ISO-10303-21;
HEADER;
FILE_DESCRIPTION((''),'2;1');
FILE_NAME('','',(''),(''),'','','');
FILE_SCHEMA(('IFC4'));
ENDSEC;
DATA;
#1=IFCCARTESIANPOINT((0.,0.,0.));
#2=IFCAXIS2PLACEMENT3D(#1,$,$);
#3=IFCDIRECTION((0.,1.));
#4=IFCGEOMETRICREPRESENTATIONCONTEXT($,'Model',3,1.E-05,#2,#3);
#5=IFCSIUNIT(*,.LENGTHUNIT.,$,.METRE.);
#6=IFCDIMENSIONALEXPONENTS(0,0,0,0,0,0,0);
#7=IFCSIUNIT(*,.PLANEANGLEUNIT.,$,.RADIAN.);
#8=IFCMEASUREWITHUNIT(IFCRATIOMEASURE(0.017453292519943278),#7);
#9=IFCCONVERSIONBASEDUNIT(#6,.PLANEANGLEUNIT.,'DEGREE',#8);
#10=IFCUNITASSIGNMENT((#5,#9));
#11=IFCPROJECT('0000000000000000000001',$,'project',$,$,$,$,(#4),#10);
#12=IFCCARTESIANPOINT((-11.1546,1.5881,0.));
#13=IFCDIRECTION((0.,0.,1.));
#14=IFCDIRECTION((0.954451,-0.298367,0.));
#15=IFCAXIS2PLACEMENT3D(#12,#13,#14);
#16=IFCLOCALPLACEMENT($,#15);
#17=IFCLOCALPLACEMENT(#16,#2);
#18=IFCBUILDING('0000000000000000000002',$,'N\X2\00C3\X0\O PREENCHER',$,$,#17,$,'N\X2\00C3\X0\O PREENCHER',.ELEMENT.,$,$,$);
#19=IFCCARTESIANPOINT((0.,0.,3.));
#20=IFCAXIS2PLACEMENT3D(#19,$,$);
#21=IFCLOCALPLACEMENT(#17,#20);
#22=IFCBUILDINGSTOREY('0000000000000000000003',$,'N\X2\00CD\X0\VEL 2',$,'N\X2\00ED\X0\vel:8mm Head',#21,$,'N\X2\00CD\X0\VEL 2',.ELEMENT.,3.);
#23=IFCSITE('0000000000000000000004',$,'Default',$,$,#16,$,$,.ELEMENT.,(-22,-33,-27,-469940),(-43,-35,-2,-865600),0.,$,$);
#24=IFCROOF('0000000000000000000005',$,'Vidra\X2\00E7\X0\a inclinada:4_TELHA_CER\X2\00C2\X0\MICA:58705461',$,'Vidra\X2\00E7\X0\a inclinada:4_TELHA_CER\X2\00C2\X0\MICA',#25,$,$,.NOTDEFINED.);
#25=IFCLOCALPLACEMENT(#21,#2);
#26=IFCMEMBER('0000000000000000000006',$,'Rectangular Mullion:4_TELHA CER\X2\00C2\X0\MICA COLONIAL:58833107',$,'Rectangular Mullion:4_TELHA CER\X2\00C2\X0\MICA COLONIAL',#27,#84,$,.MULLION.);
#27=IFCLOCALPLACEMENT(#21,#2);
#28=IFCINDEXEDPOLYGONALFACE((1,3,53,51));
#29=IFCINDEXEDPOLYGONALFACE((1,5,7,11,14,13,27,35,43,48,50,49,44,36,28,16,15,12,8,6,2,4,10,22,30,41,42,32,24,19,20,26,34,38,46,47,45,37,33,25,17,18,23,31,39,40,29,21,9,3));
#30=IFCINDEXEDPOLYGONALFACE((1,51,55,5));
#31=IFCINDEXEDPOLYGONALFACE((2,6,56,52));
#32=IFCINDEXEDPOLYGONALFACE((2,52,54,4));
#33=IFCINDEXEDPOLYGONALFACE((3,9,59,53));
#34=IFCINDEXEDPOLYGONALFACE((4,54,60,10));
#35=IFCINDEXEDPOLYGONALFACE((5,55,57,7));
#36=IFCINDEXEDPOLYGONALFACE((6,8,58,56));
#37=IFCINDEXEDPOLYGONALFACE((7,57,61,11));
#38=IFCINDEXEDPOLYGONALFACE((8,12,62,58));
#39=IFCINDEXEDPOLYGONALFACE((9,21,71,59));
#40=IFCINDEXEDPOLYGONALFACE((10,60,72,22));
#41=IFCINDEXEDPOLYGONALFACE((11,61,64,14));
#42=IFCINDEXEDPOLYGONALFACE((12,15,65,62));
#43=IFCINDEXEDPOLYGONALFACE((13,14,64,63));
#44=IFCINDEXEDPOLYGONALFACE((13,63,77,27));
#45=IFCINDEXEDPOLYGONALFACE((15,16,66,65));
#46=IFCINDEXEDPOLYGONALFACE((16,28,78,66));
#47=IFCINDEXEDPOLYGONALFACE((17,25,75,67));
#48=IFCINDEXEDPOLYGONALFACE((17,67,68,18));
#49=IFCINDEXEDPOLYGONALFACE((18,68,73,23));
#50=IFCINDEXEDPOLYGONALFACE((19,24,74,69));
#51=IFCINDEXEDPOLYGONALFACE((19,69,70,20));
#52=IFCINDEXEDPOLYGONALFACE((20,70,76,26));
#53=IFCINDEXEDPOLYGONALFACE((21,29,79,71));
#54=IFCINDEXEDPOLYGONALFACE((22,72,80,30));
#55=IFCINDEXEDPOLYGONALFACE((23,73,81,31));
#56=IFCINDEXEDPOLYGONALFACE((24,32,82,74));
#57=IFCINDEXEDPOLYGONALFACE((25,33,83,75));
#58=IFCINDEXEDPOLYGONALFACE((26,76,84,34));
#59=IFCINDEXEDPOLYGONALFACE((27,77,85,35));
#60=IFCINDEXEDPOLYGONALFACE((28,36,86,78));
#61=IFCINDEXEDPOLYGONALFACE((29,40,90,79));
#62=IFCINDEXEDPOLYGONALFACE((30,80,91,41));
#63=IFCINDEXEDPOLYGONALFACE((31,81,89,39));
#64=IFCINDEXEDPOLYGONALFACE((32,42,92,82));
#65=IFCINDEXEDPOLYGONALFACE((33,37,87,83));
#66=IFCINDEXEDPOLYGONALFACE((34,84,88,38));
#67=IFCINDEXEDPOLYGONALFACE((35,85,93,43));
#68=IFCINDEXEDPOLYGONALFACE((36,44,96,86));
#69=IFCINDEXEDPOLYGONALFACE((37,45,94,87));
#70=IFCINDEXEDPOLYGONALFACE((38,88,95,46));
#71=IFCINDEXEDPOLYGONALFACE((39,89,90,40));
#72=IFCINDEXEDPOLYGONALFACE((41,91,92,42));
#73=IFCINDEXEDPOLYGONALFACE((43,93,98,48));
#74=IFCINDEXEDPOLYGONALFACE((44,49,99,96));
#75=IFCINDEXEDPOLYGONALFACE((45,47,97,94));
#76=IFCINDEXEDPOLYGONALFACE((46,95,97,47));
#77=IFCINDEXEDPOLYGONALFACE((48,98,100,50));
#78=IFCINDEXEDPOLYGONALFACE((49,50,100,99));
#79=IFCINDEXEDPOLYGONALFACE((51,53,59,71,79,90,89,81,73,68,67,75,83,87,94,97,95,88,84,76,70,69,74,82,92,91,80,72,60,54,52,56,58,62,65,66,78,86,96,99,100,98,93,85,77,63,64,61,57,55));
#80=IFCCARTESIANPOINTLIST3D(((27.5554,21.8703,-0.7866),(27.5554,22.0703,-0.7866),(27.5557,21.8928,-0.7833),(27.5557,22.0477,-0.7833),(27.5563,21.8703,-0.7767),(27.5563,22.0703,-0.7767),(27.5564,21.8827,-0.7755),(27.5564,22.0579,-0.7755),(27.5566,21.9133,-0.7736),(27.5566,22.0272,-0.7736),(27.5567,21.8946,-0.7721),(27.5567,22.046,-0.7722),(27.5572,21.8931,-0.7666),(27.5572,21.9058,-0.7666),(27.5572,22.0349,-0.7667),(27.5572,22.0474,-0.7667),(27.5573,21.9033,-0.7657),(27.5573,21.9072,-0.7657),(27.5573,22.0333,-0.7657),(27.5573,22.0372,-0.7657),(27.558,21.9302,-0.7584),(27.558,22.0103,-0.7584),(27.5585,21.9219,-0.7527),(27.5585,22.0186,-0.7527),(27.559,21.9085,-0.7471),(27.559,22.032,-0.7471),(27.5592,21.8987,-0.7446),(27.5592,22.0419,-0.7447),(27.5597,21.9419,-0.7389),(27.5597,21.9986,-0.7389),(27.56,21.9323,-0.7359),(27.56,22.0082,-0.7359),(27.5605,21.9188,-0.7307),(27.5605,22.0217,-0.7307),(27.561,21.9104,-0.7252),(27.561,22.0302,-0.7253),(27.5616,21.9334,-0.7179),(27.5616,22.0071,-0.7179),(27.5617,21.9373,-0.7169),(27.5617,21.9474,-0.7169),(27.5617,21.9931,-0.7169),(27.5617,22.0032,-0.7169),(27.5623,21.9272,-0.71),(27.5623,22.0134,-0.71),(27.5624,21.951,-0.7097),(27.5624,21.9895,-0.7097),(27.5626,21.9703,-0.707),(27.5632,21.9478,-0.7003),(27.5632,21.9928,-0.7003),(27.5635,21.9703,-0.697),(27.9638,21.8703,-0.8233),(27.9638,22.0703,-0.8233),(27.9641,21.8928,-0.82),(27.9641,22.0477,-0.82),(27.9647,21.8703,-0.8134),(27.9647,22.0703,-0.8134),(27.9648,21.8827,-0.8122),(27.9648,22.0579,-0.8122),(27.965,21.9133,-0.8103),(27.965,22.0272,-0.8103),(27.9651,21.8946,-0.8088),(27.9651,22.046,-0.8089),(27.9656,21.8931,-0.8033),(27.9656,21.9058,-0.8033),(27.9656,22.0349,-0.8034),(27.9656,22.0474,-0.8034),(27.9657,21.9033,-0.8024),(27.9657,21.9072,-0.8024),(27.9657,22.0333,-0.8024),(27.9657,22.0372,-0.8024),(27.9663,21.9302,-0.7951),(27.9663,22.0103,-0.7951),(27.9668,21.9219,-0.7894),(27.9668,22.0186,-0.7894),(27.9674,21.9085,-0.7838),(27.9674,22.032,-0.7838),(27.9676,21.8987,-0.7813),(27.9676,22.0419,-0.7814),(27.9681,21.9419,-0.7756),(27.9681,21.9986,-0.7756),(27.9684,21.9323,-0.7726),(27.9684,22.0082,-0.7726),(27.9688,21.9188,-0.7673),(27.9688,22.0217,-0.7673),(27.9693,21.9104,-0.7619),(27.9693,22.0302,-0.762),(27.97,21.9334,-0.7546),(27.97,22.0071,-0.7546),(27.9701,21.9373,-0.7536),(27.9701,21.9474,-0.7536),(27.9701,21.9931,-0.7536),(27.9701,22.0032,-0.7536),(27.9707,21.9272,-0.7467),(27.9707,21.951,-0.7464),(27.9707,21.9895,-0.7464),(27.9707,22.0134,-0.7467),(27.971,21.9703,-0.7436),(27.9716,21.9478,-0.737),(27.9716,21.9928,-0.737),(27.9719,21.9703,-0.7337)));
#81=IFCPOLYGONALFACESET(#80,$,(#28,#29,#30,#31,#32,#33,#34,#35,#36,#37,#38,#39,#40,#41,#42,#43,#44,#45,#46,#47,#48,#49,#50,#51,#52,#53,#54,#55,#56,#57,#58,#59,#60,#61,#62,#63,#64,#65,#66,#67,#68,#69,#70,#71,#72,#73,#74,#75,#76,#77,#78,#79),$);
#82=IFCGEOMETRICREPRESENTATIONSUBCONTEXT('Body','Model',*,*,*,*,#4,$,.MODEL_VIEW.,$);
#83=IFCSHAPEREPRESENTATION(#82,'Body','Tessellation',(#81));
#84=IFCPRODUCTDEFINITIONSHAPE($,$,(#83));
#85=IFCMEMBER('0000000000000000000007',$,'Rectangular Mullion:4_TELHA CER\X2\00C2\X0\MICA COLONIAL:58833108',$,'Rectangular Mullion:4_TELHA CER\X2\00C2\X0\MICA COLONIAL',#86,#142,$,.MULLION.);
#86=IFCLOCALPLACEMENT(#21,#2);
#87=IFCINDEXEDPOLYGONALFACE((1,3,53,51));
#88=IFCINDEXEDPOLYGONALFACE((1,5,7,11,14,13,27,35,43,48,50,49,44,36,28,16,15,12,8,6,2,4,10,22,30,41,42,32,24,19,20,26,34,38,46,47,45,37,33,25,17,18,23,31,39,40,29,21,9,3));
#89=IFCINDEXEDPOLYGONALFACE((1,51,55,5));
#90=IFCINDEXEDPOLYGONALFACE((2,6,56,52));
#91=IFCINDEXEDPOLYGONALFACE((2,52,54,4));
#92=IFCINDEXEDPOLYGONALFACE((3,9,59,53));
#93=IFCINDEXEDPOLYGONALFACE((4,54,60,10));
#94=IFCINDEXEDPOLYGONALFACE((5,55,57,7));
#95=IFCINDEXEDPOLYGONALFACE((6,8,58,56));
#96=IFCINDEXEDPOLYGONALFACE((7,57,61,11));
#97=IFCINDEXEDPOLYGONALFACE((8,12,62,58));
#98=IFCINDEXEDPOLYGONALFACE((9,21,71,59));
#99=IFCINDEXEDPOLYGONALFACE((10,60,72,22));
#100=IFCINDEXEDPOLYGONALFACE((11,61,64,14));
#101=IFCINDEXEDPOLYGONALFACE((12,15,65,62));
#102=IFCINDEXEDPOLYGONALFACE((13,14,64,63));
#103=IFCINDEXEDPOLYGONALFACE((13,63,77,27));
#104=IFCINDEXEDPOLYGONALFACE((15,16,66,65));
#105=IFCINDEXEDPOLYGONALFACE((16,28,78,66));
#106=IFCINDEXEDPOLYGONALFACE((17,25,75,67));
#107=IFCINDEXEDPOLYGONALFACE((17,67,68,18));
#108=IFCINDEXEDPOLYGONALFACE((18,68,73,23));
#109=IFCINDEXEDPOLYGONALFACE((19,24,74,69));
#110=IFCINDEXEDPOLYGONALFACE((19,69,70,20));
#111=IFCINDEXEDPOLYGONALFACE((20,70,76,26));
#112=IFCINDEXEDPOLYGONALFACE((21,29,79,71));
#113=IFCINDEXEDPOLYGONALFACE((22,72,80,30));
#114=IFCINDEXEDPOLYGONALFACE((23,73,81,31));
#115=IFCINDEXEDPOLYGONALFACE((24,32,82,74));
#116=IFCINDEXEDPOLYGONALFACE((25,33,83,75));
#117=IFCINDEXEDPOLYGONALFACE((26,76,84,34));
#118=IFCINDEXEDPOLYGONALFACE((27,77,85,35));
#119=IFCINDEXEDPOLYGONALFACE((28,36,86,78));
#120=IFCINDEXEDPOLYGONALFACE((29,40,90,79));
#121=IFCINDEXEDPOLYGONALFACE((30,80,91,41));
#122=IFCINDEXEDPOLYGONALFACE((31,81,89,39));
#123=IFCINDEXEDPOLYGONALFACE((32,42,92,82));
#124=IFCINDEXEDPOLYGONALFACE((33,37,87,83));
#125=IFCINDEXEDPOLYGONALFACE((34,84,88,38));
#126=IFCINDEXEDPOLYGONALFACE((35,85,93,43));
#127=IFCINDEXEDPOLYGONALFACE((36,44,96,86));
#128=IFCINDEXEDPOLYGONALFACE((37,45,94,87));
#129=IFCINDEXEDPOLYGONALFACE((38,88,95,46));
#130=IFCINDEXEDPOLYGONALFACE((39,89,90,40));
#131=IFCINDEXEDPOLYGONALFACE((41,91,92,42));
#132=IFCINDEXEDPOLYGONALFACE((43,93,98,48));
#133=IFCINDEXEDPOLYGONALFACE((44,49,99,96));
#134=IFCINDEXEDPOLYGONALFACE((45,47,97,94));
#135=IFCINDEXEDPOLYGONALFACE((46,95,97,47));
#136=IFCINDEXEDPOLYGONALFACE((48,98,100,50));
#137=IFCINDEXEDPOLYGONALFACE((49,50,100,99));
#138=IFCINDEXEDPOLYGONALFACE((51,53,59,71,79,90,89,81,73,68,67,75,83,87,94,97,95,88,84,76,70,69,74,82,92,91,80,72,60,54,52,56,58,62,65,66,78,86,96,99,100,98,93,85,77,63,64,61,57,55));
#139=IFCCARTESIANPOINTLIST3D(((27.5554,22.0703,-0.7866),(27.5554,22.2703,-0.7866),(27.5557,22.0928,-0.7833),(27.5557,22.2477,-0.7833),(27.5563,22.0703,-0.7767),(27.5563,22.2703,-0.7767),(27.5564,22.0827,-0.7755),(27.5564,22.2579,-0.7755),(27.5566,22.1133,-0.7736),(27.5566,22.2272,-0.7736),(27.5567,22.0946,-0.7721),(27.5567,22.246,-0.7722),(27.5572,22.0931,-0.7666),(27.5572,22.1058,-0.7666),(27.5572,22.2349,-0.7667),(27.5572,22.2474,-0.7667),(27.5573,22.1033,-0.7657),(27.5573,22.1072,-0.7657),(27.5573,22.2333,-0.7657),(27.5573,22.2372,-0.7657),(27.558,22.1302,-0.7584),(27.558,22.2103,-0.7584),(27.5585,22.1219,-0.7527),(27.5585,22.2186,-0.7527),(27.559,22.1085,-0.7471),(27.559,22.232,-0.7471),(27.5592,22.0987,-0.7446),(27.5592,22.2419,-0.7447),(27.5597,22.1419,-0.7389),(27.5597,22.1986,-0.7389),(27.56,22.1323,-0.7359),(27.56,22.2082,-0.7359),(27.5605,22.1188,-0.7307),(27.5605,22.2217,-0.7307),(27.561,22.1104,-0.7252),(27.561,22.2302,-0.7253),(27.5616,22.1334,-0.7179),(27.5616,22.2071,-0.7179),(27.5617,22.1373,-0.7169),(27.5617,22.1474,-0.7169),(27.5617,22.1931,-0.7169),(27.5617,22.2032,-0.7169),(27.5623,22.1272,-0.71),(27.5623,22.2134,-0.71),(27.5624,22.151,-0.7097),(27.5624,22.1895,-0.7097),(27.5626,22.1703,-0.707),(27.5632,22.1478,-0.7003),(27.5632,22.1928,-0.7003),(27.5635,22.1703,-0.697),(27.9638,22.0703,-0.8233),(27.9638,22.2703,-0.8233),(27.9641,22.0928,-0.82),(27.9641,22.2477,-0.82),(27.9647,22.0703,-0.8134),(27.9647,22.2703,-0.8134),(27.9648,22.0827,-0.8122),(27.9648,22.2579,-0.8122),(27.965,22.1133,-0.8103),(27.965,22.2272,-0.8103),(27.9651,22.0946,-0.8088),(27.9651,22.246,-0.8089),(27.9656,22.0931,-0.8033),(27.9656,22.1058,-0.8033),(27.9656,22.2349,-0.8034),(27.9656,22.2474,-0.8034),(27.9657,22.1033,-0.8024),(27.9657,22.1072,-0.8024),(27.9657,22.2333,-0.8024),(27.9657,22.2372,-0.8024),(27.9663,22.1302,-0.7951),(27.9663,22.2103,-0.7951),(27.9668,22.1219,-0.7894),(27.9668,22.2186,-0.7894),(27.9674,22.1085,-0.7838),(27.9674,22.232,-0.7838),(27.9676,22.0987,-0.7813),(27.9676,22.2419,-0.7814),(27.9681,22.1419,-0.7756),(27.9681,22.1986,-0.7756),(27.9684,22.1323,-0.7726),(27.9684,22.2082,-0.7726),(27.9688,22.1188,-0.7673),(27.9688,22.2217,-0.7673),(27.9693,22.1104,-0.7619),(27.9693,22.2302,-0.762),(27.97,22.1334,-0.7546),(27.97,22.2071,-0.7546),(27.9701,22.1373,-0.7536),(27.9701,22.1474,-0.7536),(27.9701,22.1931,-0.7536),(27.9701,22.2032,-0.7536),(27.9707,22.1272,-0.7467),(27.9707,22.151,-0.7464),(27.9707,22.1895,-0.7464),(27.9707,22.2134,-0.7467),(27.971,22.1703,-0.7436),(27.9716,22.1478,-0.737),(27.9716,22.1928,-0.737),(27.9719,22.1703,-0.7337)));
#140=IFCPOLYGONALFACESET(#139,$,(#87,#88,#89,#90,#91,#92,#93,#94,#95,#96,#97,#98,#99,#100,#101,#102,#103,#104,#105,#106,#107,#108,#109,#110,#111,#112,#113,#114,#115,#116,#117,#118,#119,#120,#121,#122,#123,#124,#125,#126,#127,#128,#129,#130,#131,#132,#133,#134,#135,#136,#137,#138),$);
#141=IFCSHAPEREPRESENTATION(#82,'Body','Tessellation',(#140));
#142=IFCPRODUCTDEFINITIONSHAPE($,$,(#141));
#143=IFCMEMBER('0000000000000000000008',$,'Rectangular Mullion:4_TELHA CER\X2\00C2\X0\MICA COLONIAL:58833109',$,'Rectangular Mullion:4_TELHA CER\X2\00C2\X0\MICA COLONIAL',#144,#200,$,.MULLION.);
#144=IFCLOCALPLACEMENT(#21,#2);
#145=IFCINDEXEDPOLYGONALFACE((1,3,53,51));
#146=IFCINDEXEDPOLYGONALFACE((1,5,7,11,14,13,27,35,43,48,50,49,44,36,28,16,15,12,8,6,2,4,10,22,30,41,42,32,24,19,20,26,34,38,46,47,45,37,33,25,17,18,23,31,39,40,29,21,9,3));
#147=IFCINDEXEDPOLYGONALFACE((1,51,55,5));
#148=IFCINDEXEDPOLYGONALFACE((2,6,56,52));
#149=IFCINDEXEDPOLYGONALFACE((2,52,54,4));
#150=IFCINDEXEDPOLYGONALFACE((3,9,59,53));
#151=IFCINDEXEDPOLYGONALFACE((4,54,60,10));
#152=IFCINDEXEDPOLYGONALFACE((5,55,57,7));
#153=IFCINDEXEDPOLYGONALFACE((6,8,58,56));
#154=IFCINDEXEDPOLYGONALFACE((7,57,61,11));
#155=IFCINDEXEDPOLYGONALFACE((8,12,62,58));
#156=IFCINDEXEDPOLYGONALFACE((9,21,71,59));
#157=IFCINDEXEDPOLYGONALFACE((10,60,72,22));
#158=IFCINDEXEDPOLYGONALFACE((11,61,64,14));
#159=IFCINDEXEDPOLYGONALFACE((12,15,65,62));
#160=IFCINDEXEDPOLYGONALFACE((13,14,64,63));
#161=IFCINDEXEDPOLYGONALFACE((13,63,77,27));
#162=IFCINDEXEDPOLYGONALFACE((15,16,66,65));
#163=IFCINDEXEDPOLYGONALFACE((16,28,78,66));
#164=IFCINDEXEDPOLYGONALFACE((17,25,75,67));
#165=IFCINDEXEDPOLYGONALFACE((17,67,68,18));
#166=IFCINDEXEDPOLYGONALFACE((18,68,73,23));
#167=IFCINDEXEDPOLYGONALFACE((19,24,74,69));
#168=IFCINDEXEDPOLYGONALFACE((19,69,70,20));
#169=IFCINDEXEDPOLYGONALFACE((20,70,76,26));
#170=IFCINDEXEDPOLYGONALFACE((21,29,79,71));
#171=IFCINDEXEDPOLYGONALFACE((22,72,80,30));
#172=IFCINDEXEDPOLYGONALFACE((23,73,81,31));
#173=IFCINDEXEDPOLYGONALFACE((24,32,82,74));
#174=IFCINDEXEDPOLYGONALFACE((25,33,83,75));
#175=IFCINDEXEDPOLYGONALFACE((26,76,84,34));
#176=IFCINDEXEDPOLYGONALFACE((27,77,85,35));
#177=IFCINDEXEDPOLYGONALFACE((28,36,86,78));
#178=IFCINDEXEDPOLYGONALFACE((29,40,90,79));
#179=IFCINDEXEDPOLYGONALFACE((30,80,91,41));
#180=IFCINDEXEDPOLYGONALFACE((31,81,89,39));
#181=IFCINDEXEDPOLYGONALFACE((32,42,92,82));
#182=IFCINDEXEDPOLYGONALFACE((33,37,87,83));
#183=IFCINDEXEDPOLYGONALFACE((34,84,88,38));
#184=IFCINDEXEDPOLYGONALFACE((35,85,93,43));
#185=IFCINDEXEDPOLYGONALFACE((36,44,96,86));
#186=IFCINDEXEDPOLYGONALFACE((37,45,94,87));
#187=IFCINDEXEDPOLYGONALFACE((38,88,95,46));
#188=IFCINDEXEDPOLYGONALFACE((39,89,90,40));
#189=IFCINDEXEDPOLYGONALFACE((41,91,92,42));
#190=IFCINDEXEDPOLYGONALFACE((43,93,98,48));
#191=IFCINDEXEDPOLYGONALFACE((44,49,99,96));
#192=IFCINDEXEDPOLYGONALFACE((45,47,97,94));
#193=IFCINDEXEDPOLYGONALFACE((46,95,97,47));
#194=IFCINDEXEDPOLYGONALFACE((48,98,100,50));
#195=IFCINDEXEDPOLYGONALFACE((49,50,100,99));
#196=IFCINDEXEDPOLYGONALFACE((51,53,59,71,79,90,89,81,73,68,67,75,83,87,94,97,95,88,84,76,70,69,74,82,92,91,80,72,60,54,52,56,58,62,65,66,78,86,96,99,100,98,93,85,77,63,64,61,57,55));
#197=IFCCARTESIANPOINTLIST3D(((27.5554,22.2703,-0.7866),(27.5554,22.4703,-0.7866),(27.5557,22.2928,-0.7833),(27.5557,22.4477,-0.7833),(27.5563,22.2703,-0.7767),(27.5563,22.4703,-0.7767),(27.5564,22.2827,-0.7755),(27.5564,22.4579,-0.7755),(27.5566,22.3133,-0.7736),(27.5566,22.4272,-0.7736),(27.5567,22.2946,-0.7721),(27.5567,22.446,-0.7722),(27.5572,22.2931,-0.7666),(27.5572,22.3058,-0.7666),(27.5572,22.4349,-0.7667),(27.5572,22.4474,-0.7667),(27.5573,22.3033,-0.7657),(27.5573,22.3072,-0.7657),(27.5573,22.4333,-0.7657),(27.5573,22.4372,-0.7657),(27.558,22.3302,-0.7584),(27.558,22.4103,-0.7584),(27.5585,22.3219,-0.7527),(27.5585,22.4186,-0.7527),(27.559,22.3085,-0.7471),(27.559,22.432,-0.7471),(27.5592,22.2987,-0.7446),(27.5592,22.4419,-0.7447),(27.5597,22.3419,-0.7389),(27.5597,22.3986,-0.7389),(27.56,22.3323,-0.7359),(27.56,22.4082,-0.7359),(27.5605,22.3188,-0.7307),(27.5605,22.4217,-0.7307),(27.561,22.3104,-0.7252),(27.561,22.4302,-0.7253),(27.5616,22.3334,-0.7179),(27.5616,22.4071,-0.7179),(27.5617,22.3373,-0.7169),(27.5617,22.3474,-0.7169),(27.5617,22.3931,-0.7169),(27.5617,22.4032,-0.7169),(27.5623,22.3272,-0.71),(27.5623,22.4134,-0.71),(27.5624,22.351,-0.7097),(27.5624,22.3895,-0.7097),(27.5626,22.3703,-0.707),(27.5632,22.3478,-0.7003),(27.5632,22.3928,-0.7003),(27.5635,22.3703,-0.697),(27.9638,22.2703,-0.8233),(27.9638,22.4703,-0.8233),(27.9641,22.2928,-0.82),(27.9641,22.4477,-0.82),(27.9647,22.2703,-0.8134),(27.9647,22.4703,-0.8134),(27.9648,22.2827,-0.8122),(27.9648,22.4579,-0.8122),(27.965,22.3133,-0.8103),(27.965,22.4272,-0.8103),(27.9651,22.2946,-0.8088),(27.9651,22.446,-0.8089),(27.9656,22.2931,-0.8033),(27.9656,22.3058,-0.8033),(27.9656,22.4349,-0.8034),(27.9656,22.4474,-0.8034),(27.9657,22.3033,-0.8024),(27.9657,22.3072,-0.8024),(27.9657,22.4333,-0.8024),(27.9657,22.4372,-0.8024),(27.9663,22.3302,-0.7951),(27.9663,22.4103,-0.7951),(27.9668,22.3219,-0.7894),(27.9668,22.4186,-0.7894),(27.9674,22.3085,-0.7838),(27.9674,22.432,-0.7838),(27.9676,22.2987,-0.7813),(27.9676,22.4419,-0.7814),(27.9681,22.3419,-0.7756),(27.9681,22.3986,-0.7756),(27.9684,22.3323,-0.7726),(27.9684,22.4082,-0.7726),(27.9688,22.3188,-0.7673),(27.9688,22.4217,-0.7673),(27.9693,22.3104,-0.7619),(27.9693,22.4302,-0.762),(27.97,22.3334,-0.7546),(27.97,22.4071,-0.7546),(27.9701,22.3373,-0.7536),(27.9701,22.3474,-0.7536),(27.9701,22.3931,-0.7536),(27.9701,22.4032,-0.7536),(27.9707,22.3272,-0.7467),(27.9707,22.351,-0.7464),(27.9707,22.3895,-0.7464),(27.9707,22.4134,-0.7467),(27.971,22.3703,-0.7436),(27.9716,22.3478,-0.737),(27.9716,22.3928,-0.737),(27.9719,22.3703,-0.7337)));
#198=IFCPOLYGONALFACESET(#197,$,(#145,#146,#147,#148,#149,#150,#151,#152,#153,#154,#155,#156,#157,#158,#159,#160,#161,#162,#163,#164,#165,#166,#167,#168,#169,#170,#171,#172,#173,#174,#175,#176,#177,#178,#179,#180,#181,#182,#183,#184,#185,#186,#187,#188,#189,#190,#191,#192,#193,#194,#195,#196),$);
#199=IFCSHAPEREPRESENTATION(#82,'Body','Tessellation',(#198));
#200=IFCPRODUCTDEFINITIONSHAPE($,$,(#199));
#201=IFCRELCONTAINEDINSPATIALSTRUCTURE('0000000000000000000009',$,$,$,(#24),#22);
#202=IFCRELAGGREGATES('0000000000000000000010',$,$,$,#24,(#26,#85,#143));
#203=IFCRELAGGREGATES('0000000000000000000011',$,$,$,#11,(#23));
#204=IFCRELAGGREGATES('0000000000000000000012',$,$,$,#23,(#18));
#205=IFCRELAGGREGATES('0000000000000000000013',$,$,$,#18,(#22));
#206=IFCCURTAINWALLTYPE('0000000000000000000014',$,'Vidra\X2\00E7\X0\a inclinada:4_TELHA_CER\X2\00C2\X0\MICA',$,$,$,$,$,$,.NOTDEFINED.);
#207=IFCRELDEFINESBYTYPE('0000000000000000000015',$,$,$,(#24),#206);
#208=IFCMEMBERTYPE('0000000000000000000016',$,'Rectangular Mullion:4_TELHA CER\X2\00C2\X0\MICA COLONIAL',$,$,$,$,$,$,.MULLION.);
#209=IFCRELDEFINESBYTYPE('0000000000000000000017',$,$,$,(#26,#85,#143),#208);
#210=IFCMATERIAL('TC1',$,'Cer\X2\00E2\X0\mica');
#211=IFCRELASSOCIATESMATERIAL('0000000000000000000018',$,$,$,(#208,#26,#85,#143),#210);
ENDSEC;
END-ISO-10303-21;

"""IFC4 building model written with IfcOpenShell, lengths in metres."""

from ifc_helpers import new_model, entity, si_unit, converted_unit, direction, frame, origin, place, context, subcontext, project, spatial, line, arc, indexed_curve, outline, extrude, source, transform, mapped, material, type_object, type_shapes, element, aggregate, save


model = new_model("IFC4")

# Units and contexts
model_context = context("Model", 3, precision=1e-05, world=origin(), true_north=direction((0.0, 1.0)))
body_context = subcontext(model_context, "Body", "Model", "MODEL_VIEW")
ifc_project = project(units=[si_unit("LENGTHUNIT", "METRE"), converted_unit("PLANEANGLEUNIT", "DEGREE", entity("IfcRatioMeasure", 0.017453292519943278), si_unit("PLANEANGLEUNIT", "RADIAN"), dimensions=[0, 0, 0, 0, 0, 0, 0])], contexts=[model_context])

# Site, building, storey
site_placement = place(None, frame((-11.1546, 1.5881, 0.0), z_axis=(0.0, 0.0, 1.0), x_axis=(0.954451, -0.298367, 0.0)))
site = spatial("IfcSite", under=ifc_project, at=site_placement, Name="Default", CompositionType="ELEMENT", RefLatitude=(-22, -33, -27, -469940), RefLongitude=(-43, -35, -2, -865600), RefElevation=0.0)
building_placement = place(site_placement, origin())
building = spatial("IfcBuilding", under=site, at=building_placement, Name="NÃO PREENCHER", LongName="NÃO PREENCHER", CompositionType="ELEMENT")
storey_placement = place(building_placement, frame((0.0, 0.0, 3.0)))
storey = spatial("IfcBuildingStorey", under=building, at=storey_placement, Name="NÍVEL 2", ObjectType="Nível:8mm Head", LongName="NÍVEL 2", CompositionType="ELEMENT", Elevation=3.0)

# Roof, members
curtain_wall_type = type_object("IfcCurtainWallType", Name="Vidraça inclinada:4_TELHA_CERÂMICA", PredefinedType="NOTDEFINED")
roof_placement = place(storey_placement, frame((0.0, 0.0, -3.0)))
roof = element("IfcRoof", 1, at=roof_placement, inside=storey, type_object=curtain_wall_type, Name="Vidraça inclinada:4_TELHA_CERÂMICA:58705461", ObjectType="Vidraça inclinada:4_TELHA_CERÂMICA", PredefinedType="NOTDEFINED")
ifc_material = material(Name="TC1", Category="Cerâmica")
member_type_1 = type_object("IfcMemberType", Name="Rectangular Mullion:4_TELHA CERÂMICA COLONIAL", PredefinedType="MULLION", material=ifc_material)
shared_shape_1 = source(origin(), body_context, "Body", "SweptSolid", [
    extrude(outline(indexed_curve([(-0.029, -0.1), (-0.019, -0.1), (-0.0164, -0.0815), (-0.0089, -0.0645), (-0.0089, -0.0771), (0.061, 0.0), (-0.009, 0.0771), (-0.009, 0.0646), (-0.0165, 0.0816), (-0.019, 0.1), (-0.029, 0.1), (-0.0089, 0.0479), (0.041, 0.0229), (0.041, 0.0329), (0.0131, 0.0425), (-0.008, 0.0631), (-0.008, 0.067), (0.051, 0.0), (-0.008, -0.067), (-0.008, -0.0631), (0.0131, -0.0425), (0.041, -0.0329), (0.041, -0.0229), (-0.0089, -0.0479)], segments=[line(1, 2), arc(2, 3, 4), line(4, 5), arc(5, 6, 7), line(7, 8), arc(8, 9, 10), line(10, 11), arc(11, 12, 13), line(13, 14), arc(14, 15, 16), line(16, 17), arc(17, 18, 19), line(19, 20), arc(20, 21, 22), line(22, 23), arc(23, 24, 1)], self_intersect=False)), frame((0.0, -0.029, -0.41), z_axis=(0.0, 0.0, 1.0), x_axis=(0.0, -1.0, 0.0)), (0.0, 0.0, 1.0), 0.41),
])
type_shapes(member_type_1, [shared_shape_1])
member_1_placement = place(roof_placement, frame((27.5554, 21.9703, 2.2134), z_axis=(-0.99599, 0.0, 0.089469), x_axis=(0.0, 1.0, 0.0)))
member_1 = element("IfcMember", 2, at=member_1_placement, type_object=member_type_1, material=ifc_material, Name="Rectangular Mullion:4_TELHA CERÂMICA COLONIAL:58833107", ObjectType="Rectangular Mullion:4_TELHA CERÂMICA COLONIAL", PredefinedType="MULLION", context=body_context, shape_type="MappedRepresentation", body=[
    mapped(shared_shape_1, transform((0.0, 0.0, 0.0), scale=1.0)),
])
member_2_placement = place(roof_placement, frame((27.5554, 22.1703, 2.2134), z_axis=(-0.99599, 0.0, 0.089469), x_axis=(0.0, 1.0, 0.0)))
member_2 = element("IfcMember", 3, at=member_2_placement, type_object=member_type_1, material=ifc_material, Name="Rectangular Mullion:4_TELHA CERÂMICA COLONIAL:58833108", ObjectType="Rectangular Mullion:4_TELHA CERÂMICA COLONIAL", PredefinedType="MULLION", context=body_context, shape_type="MappedRepresentation", body=[
    mapped(shared_shape_1, transform((0.0, 0.0, 0.0), scale=1.0)),
])
member_3_placement = place(roof_placement, frame((27.5554, 22.3703, 2.2134), z_axis=(-0.99599, 0.0, 0.089469), x_axis=(0.0, 1.0, 0.0)))
member_3 = element("IfcMember", 4, at=member_3_placement, type_object=member_type_1, material=ifc_material, Name="Rectangular Mullion:4_TELHA CERÂMICA COLONIAL:58833109", ObjectType="Rectangular Mullion:4_TELHA CERÂMICA COLONIAL", PredefinedType="MULLION", context=body_context, shape_type="MappedRepresentation", body=[
    mapped(shared_shape_1, transform((0.0, 0.0, 0.0), scale=1.0)),
])
aggregate(roof, [member_1, member_2, member_3])

save(model, "model.ifc")
